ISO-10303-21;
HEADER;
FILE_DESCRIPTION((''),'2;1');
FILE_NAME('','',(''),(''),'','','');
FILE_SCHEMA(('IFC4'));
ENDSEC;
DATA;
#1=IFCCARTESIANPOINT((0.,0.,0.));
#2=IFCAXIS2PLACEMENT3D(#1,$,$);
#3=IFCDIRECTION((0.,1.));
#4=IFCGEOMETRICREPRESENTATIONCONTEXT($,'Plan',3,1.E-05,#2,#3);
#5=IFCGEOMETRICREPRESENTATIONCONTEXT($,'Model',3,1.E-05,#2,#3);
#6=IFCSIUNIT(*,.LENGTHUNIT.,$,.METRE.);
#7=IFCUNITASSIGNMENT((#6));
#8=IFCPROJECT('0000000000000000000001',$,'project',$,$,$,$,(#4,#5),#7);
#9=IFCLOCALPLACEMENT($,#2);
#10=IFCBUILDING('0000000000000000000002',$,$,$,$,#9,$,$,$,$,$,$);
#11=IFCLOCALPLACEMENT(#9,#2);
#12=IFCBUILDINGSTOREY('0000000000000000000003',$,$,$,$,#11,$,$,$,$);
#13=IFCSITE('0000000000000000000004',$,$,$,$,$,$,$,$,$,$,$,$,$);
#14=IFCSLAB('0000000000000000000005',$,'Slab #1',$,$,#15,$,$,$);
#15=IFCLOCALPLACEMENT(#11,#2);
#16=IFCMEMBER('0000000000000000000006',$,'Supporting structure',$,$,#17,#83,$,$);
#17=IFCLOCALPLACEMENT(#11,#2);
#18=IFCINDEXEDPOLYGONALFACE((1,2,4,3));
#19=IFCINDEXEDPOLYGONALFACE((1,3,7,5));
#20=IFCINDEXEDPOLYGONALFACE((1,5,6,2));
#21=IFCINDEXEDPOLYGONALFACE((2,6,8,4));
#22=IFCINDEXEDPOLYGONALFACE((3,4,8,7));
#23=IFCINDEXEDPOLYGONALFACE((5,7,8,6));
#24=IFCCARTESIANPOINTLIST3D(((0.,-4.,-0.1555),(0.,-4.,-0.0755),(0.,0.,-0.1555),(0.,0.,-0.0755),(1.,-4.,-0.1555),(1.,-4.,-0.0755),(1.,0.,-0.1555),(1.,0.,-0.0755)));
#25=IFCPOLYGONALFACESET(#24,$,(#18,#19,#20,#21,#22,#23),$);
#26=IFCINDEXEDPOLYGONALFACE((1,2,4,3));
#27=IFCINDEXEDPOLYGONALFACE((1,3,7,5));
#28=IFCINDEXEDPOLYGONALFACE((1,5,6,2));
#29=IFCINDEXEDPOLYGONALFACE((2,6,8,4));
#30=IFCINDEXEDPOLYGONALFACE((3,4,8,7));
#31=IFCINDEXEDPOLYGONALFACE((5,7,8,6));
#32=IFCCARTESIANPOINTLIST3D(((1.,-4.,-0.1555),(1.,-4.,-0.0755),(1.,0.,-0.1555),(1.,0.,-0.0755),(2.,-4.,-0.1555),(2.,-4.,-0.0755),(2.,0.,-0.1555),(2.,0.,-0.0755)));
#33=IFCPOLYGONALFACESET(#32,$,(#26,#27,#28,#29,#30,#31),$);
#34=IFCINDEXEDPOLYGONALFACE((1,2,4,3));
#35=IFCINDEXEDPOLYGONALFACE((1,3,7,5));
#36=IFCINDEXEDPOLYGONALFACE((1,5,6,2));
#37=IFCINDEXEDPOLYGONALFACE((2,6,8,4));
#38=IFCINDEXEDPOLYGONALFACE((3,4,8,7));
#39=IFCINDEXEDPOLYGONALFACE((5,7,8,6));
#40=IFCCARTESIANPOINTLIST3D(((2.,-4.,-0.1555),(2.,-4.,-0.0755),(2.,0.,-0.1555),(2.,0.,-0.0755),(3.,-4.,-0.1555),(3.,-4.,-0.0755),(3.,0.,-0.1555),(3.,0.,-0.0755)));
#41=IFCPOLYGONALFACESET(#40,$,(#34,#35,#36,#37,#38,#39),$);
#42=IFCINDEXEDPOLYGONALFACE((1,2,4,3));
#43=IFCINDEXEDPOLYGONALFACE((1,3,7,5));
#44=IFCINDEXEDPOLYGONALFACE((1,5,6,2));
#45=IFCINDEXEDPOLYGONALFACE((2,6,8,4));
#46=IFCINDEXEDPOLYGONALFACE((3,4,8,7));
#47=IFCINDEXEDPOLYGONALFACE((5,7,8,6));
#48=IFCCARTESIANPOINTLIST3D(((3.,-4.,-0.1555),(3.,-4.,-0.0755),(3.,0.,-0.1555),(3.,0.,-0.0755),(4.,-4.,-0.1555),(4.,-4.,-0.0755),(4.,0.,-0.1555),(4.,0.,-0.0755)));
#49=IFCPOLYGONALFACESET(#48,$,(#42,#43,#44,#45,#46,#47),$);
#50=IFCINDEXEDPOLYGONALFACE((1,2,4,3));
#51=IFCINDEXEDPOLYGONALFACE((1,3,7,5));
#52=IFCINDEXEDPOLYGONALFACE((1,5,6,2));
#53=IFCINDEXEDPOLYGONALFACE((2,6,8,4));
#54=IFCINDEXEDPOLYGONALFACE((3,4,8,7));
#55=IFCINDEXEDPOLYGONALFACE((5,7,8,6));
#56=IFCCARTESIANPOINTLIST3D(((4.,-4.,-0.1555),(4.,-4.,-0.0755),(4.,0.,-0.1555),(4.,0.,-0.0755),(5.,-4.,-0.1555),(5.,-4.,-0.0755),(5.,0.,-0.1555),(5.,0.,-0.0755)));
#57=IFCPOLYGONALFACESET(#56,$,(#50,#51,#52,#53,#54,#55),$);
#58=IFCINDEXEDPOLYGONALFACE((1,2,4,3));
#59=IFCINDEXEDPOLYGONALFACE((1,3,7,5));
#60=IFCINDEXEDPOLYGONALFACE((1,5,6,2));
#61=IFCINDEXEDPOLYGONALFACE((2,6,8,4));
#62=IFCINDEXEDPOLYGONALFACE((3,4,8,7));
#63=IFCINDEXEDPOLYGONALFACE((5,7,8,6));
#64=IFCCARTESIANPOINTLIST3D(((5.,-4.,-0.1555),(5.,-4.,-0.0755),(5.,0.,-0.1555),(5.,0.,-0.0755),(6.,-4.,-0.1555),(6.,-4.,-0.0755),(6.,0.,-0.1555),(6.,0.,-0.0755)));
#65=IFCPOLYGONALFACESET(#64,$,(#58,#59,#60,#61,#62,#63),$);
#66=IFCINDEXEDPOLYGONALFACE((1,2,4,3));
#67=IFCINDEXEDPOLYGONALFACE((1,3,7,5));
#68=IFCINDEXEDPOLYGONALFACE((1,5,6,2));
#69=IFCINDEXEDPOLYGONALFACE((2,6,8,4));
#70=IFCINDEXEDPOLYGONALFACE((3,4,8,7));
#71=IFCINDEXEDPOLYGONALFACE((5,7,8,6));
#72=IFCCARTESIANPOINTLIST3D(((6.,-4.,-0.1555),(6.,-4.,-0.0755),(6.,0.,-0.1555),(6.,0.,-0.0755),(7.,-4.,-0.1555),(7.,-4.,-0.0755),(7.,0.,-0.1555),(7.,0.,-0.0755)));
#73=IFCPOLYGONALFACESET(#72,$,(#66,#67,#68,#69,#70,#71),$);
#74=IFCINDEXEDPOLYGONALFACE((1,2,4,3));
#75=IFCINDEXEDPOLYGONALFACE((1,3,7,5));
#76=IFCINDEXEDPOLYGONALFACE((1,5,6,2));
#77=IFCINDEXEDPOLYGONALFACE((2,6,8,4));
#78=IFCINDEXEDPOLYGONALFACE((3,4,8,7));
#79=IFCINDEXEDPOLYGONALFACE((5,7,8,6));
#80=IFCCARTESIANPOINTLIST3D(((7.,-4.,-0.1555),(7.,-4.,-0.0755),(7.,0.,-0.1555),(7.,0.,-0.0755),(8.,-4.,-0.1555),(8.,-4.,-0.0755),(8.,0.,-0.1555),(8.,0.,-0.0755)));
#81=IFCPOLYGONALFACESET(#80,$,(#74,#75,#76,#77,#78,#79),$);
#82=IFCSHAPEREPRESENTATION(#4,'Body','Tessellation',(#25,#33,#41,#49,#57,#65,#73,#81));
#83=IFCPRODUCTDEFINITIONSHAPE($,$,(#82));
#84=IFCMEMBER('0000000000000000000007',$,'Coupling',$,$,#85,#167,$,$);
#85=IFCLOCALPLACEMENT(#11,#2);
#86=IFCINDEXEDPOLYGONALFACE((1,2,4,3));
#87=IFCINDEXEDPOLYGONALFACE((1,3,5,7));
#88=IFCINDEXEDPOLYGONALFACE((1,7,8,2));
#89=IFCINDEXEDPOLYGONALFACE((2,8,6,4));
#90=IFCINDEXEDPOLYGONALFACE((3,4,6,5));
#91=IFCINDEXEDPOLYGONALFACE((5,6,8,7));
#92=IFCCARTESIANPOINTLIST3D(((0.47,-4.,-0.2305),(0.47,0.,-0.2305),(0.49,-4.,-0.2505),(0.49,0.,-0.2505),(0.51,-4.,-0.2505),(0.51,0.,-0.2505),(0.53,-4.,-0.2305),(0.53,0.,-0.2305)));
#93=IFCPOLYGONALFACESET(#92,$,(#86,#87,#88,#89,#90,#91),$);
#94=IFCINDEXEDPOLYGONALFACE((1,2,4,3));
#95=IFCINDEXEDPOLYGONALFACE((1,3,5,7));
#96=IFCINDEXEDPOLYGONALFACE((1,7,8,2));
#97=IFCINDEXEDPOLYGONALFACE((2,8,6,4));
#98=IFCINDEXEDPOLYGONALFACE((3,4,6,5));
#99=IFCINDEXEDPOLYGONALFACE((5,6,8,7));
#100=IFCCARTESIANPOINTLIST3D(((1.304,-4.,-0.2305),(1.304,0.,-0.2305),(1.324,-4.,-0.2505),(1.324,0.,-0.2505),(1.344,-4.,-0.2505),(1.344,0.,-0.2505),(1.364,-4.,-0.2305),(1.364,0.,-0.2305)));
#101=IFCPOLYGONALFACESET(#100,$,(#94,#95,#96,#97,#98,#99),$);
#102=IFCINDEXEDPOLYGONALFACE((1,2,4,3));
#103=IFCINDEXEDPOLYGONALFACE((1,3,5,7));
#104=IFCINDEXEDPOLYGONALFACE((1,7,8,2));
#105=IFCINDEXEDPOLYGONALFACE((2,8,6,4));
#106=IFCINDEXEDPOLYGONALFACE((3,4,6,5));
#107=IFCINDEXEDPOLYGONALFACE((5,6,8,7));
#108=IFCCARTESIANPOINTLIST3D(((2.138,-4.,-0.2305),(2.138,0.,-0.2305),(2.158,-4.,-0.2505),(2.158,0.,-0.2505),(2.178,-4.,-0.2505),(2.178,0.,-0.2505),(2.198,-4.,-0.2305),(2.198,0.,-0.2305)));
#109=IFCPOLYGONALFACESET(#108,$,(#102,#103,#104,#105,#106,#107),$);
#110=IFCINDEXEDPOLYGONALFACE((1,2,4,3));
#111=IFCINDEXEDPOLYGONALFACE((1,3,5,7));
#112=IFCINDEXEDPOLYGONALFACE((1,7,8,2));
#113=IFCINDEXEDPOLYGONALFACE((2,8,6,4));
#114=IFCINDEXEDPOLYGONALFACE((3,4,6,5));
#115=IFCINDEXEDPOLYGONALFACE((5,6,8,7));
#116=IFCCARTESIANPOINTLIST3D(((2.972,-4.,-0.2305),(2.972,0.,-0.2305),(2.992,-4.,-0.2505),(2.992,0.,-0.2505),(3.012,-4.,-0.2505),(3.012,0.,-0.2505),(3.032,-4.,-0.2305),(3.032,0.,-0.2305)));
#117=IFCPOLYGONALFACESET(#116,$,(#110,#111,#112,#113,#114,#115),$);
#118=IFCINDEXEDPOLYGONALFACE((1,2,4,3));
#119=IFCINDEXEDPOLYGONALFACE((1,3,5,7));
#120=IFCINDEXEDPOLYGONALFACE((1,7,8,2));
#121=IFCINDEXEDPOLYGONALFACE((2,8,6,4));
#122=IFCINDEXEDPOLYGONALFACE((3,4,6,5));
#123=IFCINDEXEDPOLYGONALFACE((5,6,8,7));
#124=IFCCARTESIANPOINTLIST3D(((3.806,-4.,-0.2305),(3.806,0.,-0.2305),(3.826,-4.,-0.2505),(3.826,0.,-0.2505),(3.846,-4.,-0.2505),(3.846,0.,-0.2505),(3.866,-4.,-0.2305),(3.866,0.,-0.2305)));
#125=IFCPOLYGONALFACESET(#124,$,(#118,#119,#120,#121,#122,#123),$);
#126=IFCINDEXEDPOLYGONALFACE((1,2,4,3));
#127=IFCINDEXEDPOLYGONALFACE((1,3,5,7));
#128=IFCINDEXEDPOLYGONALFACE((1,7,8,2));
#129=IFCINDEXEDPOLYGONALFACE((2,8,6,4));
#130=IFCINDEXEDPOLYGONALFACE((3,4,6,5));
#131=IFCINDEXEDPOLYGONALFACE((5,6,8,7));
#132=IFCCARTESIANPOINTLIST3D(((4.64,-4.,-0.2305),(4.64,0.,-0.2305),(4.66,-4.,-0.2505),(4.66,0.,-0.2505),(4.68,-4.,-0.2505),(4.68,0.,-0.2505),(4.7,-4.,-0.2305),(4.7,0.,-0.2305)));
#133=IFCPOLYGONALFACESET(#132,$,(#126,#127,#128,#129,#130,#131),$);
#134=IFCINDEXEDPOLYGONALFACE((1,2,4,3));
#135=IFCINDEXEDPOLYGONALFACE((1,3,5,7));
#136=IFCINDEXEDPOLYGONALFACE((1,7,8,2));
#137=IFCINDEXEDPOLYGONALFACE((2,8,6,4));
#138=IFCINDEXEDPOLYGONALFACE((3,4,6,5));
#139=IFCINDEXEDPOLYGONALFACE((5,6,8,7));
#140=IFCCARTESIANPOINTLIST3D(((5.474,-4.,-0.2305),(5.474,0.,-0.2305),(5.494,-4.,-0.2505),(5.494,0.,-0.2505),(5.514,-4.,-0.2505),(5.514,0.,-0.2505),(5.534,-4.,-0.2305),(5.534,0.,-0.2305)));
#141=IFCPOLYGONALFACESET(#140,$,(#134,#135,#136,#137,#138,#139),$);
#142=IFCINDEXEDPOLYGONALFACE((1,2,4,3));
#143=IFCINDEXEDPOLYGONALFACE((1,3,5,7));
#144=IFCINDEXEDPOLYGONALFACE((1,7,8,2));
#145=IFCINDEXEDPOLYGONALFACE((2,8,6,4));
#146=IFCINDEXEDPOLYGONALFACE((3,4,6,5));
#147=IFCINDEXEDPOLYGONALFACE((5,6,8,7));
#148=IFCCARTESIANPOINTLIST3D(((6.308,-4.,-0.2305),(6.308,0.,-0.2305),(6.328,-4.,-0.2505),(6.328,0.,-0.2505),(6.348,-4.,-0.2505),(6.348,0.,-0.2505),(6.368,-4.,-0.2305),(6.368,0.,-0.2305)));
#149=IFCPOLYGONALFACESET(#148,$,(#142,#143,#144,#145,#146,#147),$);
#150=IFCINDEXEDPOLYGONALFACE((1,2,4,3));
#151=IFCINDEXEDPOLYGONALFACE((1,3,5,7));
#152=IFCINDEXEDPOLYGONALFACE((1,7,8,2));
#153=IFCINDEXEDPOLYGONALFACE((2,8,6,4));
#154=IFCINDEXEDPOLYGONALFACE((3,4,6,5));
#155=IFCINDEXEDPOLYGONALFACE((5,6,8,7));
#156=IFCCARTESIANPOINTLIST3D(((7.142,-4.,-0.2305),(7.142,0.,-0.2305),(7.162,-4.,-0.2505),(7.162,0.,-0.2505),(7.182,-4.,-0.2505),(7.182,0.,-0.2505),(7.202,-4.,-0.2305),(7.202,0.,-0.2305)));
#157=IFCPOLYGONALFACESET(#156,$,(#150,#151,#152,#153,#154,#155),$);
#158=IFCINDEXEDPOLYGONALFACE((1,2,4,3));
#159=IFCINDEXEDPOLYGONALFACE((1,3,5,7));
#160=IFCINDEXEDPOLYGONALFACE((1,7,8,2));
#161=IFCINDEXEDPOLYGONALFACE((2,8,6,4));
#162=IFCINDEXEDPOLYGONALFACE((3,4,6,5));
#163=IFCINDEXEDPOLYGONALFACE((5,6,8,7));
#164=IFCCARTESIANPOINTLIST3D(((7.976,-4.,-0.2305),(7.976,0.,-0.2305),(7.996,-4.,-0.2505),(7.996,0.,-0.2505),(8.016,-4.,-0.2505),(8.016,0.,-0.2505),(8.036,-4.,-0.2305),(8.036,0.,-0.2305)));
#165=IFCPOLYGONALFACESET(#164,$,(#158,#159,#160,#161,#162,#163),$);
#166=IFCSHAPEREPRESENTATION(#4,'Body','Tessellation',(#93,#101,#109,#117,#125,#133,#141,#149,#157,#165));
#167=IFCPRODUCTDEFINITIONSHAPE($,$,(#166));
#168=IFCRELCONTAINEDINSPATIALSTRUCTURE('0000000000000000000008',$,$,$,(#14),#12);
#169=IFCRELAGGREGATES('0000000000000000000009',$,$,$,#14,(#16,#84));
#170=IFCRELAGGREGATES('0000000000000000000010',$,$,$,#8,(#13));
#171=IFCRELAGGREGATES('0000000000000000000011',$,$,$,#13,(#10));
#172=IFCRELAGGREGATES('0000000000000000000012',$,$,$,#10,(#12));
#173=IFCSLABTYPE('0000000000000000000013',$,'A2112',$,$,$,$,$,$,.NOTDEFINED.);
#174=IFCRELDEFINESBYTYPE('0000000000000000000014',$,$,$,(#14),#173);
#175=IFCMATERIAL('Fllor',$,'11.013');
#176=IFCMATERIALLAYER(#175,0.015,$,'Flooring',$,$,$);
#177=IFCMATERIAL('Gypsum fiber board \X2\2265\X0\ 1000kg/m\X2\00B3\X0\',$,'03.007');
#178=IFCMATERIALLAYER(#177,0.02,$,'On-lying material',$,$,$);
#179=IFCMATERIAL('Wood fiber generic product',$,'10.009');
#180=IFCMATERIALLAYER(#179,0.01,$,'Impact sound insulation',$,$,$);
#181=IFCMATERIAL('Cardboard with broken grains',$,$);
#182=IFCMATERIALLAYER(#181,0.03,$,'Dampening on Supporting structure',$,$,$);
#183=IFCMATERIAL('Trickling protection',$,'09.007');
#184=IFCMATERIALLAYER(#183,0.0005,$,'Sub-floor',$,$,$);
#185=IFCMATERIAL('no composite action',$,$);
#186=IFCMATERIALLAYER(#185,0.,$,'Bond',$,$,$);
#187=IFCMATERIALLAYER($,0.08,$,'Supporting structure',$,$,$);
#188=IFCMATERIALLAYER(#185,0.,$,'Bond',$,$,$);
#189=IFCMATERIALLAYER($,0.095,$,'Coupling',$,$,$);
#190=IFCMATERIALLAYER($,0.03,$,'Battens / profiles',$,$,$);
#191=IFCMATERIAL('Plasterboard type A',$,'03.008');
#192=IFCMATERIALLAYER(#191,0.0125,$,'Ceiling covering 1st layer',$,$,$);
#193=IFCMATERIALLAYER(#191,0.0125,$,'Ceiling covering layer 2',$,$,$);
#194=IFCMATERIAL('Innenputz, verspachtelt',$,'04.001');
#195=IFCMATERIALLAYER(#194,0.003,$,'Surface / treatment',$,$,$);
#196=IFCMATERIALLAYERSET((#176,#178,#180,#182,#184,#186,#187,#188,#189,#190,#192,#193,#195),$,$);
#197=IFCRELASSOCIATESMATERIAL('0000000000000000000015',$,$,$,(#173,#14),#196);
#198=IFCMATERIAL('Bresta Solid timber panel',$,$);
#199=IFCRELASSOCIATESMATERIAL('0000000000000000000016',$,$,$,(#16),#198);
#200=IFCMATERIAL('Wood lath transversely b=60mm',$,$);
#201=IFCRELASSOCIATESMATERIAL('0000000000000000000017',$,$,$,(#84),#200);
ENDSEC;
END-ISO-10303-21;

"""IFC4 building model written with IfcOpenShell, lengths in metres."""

from ifc_helpers import new_model, si_unit, direction, frame, frame_2d, origin, place, context, project, spatial, polyline, rectangle, outline, extrude, material, layer, layer_set, type_object, element, aggregate, save


model = new_model("IFC4")

# Units and contexts
plan_context = context("Plan", 3, precision=1e-05, world=origin(), true_north=direction((0.0, 1.0)))
model_context = context("Model", 3, precision=1e-05, world=origin(), true_north=direction((0.0, 1.0)))
ifc_project = project(units=[si_unit("LENGTHUNIT", "METRE")], contexts=[plan_context, model_context])

# Site, building, storey
site = spatial("IfcSite", under=ifc_project)
building_placement = place(None, origin())
building = spatial("IfcBuilding", under=site, at=building_placement)
storey_placement = place(building_placement, origin())
storey = spatial("IfcBuildingStorey", under=building, at=storey_placement)

# Slab, members
ifc_material_1 = material(Name="Fllor", Category="11.013")
ifc_layer_1 = layer(ifc_material_1, 0.015, Name="Flooring")
ifc_material_2 = material(Name="Gypsum fiber board ≥ 1000kg/m³", Category="03.007")
ifc_layer_2 = layer(ifc_material_2, 0.02, Name="On-lying material")
ifc_material_3 = material(Name="Wood fiber generic product", Category="10.009")
ifc_layer_3 = layer(ifc_material_3, 0.01, Name="Impact sound insulation")
ifc_material_4 = material(Name="Cardboard with broken grains")
ifc_layer_4 = layer(ifc_material_4, 0.03, Name="Dampening on Supporting structure")
ifc_material_5 = material(Name="Trickling protection", Category="09.007")
ifc_layer_5 = layer(ifc_material_5, 0.0005, Name="Sub-floor")
ifc_material_6 = material(Name="no composite action")
ifc_layer_6 = layer(ifc_material_6, 0.0, Name="Bond")
ifc_layer_7 = layer(None, 0.08, Name="Supporting structure")
ifc_layer_8 = layer(ifc_material_6, 0.0, Name="Bond")
ifc_layer_9 = layer(None, 0.095, Name="Coupling")
ifc_layer_10 = layer(None, 0.03, Name="Battens / profiles")
ifc_material_7 = material(Name="Plasterboard type A", Category="03.008")
ifc_layer_11 = layer(ifc_material_7, 0.0125, Name="Ceiling covering 1st layer")
ifc_layer_12 = layer(ifc_material_7, 0.0125, Name="Ceiling covering layer 2")
ifc_material_8 = material(Name="Innenputz, verspachtelt", Category="04.001")
ifc_layer_13 = layer(ifc_material_8, 0.003, Name="Surface / treatment")
ifc_layer_set = layer_set([ifc_layer_1, ifc_layer_2, ifc_layer_3, ifc_layer_4, ifc_layer_5, ifc_layer_6, ifc_layer_7, ifc_layer_8, ifc_layer_9, ifc_layer_10, ifc_layer_11, ifc_layer_12, ifc_layer_13])
slab_type = type_object("IfcSlabType", Name="A2112", PredefinedType="NOTDEFINED", material=ifc_layer_set)
slab_placement = place(None, frame((0.0, 0.0, 0.0), z_axis=(0.0, 0.0, -1.0), x_axis=(1.0, 0.0, 0.0)))
slab = element("IfcSlab", 1, at=slab_placement, inside=storey, type_object=slab_type, material=ifc_layer_set, Name="Slab #1")
ifc_material_9 = material(Name="Bresta Solid timber panel")
member_1_placement = place(slab_placement, origin())
member_1 = element("IfcMember", 2, at=member_1_placement, material=ifc_material_9, Name="Supporting structure", context=plan_context, shape_type="SweptSolid", body=[
    extrude(rectangle(XDim=1.0, YDim=0.08, at=frame_2d((0.5, 0.04), x_axis=(1.0, 0.0))), frame((0.0, 4.0, 0.0755), z_axis=(0.0, -1.0, 0.0), x_axis=(1.0, 0.0, 0.0)), (0.0, 0.0, 1.0), 4.0),
    extrude(rectangle(XDim=1.0, YDim=0.08, at=frame_2d((0.5, 0.04), x_axis=(1.0, 0.0))), frame((1.0, 4.0, 0.0755), z_axis=(0.0, -1.0, 0.0), x_axis=(1.0, 0.0, 0.0)), (0.0, 0.0, 1.0), 4.0),
    extrude(rectangle(XDim=1.0, YDim=0.08, at=frame_2d((0.5, 0.04), x_axis=(1.0, 0.0))), frame((2.0, 4.0, 0.0755), z_axis=(0.0, -1.0, 0.0), x_axis=(1.0, 0.0, 0.0)), (0.0, 0.0, 1.0), 4.0),
    extrude(rectangle(XDim=1.0, YDim=0.08, at=frame_2d((0.5, 0.04), x_axis=(1.0, 0.0))), frame((3.0, 4.0, 0.0755), z_axis=(0.0, -1.0, 0.0), x_axis=(1.0, 0.0, 0.0)), (0.0, 0.0, 1.0), 4.0),
    extrude(rectangle(XDim=1.0, YDim=0.08, at=frame_2d((0.5, 0.04), x_axis=(1.0, 0.0))), frame((4.0, 4.0, 0.0755), z_axis=(0.0, -1.0, 0.0), x_axis=(1.0, 0.0, 0.0)), (0.0, 0.0, 1.0), 4.0),
    extrude(rectangle(XDim=1.0, YDim=0.08, at=frame_2d((0.5, 0.04), x_axis=(1.0, 0.0))), frame((5.0, 4.0, 0.0755), z_axis=(0.0, -1.0, 0.0), x_axis=(1.0, 0.0, 0.0)), (0.0, 0.0, 1.0), 4.0),
    extrude(rectangle(XDim=1.0, YDim=0.08, at=frame_2d((0.5, 0.04), x_axis=(1.0, 0.0))), frame((6.0, 4.0, 0.0755), z_axis=(0.0, -1.0, 0.0), x_axis=(1.0, 0.0, 0.0)), (0.0, 0.0, 1.0), 4.0),
    extrude(rectangle(XDim=1.0, YDim=0.08, at=frame_2d((0.5, 0.04), x_axis=(1.0, 0.0))), frame((7.0, 4.0, 0.0755), z_axis=(0.0, -1.0, 0.0), x_axis=(1.0, 0.0, 0.0)), (0.0, 0.0, 1.0), 4.0),
])
ifc_material_10 = material(Name="Wood lath transversely b=60mm")
member_2_placement = place(slab_placement, origin())
member_2 = element("IfcMember", 3, at=member_2_placement, material=ifc_material_10, Name="Coupling", context=plan_context, shape_type="SweptSolid", body=[
    extrude(outline(polyline([(0.0, 0.0), (0.06, 0.0), (0.04, 0.02), (0.02, 0.02), (0.0, 0.0)])), frame((0.47, 4.0, 0.2305), z_axis=(0.0, -1.0, 0.0), x_axis=(1.0, 0.0, 0.0)), (0.0, 0.0, 1.0), 4.0),
    extrude(outline(polyline([(0.0, 0.0), (0.06, 0.0), (0.04, 0.02), (0.02, 0.02), (0.0, 0.0)])), frame((1.304, 4.0, 0.2305), z_axis=(0.0, -1.0, 0.0), x_axis=(1.0, 0.0, 0.0)), (0.0, 0.0, 1.0), 4.0),
    extrude(outline(polyline([(0.0, 0.0), (0.06, 0.0), (0.04, 0.02), (0.02, 0.02), (0.0, 0.0)])), frame((2.138, 4.0, 0.2305), z_axis=(0.0, -1.0, 0.0), x_axis=(1.0, 0.0, 0.0)), (0.0, 0.0, 1.0), 4.0),
    extrude(outline(polyline([(0.0, 0.0), (0.06, 0.0), (0.04, 0.02), (0.02, 0.02), (0.0, 0.0)])), frame((2.972, 4.0, 0.2305), z_axis=(0.0, -1.0, 0.0), x_axis=(1.0, 0.0, 0.0)), (0.0, 0.0, 1.0), 4.0),
    extrude(outline(polyline([(0.0, 0.0), (0.06, 0.0), (0.04, 0.02), (0.02, 0.02), (0.0, 0.0)])), frame((3.806, 4.0, 0.2305), z_axis=(0.0, -1.0, 0.0), x_axis=(1.0, 0.0, 0.0)), (0.0, 0.0, 1.0), 4.0),
    extrude(outline(polyline([(0.0, 0.0), (0.06, 0.0), (0.04, 0.02), (0.02, 0.02), (0.0, 0.0)])), frame((4.64, 4.0, 0.2305), z_axis=(0.0, -1.0, 0.0), x_axis=(1.0, 0.0, 0.0)), (0.0, 0.0, 1.0), 4.0),
    extrude(outline(polyline([(0.0, 0.0), (0.06, 0.0), (0.04, 0.02), (0.02, 0.02), (0.0, 0.0)])), frame((5.474, 4.0, 0.2305), z_axis=(0.0, -1.0, 0.0), x_axis=(1.0, 0.0, 0.0)), (0.0, 0.0, 1.0), 4.0),
    extrude(outline(polyline([(0.0, 0.0), (0.06, 0.0), (0.04, 0.02), (0.02, 0.02), (0.0, 0.0)])), frame((6.308, 4.0, 0.2305), z_axis=(0.0, -1.0, 0.0), x_axis=(1.0, 0.0, 0.0)), (0.0, 0.0, 1.0), 4.0),
    extrude(outline(polyline([(0.0, 0.0), (0.06, 0.0), (0.04, 0.02), (0.02, 0.02), (0.0, 0.0)])), frame((7.142, 4.0, 0.2305), z_axis=(0.0, -1.0, 0.0), x_axis=(1.0, 0.0, 0.0)), (0.0, 0.0, 1.0), 4.0),
    extrude(outline(polyline([(0.0, 0.0), (0.06, 0.0), (0.04, 0.02), (0.02, 0.02), (0.0, 0.0)])), frame((7.976, 4.0, 0.2305), z_axis=(0.0, -1.0, 0.0), x_axis=(1.0, 0.0, 0.0)), (0.0, 0.0, 1.0), 4.0),
])
aggregate(slab, [member_1, member_2])

save(model, "model.ifc")
